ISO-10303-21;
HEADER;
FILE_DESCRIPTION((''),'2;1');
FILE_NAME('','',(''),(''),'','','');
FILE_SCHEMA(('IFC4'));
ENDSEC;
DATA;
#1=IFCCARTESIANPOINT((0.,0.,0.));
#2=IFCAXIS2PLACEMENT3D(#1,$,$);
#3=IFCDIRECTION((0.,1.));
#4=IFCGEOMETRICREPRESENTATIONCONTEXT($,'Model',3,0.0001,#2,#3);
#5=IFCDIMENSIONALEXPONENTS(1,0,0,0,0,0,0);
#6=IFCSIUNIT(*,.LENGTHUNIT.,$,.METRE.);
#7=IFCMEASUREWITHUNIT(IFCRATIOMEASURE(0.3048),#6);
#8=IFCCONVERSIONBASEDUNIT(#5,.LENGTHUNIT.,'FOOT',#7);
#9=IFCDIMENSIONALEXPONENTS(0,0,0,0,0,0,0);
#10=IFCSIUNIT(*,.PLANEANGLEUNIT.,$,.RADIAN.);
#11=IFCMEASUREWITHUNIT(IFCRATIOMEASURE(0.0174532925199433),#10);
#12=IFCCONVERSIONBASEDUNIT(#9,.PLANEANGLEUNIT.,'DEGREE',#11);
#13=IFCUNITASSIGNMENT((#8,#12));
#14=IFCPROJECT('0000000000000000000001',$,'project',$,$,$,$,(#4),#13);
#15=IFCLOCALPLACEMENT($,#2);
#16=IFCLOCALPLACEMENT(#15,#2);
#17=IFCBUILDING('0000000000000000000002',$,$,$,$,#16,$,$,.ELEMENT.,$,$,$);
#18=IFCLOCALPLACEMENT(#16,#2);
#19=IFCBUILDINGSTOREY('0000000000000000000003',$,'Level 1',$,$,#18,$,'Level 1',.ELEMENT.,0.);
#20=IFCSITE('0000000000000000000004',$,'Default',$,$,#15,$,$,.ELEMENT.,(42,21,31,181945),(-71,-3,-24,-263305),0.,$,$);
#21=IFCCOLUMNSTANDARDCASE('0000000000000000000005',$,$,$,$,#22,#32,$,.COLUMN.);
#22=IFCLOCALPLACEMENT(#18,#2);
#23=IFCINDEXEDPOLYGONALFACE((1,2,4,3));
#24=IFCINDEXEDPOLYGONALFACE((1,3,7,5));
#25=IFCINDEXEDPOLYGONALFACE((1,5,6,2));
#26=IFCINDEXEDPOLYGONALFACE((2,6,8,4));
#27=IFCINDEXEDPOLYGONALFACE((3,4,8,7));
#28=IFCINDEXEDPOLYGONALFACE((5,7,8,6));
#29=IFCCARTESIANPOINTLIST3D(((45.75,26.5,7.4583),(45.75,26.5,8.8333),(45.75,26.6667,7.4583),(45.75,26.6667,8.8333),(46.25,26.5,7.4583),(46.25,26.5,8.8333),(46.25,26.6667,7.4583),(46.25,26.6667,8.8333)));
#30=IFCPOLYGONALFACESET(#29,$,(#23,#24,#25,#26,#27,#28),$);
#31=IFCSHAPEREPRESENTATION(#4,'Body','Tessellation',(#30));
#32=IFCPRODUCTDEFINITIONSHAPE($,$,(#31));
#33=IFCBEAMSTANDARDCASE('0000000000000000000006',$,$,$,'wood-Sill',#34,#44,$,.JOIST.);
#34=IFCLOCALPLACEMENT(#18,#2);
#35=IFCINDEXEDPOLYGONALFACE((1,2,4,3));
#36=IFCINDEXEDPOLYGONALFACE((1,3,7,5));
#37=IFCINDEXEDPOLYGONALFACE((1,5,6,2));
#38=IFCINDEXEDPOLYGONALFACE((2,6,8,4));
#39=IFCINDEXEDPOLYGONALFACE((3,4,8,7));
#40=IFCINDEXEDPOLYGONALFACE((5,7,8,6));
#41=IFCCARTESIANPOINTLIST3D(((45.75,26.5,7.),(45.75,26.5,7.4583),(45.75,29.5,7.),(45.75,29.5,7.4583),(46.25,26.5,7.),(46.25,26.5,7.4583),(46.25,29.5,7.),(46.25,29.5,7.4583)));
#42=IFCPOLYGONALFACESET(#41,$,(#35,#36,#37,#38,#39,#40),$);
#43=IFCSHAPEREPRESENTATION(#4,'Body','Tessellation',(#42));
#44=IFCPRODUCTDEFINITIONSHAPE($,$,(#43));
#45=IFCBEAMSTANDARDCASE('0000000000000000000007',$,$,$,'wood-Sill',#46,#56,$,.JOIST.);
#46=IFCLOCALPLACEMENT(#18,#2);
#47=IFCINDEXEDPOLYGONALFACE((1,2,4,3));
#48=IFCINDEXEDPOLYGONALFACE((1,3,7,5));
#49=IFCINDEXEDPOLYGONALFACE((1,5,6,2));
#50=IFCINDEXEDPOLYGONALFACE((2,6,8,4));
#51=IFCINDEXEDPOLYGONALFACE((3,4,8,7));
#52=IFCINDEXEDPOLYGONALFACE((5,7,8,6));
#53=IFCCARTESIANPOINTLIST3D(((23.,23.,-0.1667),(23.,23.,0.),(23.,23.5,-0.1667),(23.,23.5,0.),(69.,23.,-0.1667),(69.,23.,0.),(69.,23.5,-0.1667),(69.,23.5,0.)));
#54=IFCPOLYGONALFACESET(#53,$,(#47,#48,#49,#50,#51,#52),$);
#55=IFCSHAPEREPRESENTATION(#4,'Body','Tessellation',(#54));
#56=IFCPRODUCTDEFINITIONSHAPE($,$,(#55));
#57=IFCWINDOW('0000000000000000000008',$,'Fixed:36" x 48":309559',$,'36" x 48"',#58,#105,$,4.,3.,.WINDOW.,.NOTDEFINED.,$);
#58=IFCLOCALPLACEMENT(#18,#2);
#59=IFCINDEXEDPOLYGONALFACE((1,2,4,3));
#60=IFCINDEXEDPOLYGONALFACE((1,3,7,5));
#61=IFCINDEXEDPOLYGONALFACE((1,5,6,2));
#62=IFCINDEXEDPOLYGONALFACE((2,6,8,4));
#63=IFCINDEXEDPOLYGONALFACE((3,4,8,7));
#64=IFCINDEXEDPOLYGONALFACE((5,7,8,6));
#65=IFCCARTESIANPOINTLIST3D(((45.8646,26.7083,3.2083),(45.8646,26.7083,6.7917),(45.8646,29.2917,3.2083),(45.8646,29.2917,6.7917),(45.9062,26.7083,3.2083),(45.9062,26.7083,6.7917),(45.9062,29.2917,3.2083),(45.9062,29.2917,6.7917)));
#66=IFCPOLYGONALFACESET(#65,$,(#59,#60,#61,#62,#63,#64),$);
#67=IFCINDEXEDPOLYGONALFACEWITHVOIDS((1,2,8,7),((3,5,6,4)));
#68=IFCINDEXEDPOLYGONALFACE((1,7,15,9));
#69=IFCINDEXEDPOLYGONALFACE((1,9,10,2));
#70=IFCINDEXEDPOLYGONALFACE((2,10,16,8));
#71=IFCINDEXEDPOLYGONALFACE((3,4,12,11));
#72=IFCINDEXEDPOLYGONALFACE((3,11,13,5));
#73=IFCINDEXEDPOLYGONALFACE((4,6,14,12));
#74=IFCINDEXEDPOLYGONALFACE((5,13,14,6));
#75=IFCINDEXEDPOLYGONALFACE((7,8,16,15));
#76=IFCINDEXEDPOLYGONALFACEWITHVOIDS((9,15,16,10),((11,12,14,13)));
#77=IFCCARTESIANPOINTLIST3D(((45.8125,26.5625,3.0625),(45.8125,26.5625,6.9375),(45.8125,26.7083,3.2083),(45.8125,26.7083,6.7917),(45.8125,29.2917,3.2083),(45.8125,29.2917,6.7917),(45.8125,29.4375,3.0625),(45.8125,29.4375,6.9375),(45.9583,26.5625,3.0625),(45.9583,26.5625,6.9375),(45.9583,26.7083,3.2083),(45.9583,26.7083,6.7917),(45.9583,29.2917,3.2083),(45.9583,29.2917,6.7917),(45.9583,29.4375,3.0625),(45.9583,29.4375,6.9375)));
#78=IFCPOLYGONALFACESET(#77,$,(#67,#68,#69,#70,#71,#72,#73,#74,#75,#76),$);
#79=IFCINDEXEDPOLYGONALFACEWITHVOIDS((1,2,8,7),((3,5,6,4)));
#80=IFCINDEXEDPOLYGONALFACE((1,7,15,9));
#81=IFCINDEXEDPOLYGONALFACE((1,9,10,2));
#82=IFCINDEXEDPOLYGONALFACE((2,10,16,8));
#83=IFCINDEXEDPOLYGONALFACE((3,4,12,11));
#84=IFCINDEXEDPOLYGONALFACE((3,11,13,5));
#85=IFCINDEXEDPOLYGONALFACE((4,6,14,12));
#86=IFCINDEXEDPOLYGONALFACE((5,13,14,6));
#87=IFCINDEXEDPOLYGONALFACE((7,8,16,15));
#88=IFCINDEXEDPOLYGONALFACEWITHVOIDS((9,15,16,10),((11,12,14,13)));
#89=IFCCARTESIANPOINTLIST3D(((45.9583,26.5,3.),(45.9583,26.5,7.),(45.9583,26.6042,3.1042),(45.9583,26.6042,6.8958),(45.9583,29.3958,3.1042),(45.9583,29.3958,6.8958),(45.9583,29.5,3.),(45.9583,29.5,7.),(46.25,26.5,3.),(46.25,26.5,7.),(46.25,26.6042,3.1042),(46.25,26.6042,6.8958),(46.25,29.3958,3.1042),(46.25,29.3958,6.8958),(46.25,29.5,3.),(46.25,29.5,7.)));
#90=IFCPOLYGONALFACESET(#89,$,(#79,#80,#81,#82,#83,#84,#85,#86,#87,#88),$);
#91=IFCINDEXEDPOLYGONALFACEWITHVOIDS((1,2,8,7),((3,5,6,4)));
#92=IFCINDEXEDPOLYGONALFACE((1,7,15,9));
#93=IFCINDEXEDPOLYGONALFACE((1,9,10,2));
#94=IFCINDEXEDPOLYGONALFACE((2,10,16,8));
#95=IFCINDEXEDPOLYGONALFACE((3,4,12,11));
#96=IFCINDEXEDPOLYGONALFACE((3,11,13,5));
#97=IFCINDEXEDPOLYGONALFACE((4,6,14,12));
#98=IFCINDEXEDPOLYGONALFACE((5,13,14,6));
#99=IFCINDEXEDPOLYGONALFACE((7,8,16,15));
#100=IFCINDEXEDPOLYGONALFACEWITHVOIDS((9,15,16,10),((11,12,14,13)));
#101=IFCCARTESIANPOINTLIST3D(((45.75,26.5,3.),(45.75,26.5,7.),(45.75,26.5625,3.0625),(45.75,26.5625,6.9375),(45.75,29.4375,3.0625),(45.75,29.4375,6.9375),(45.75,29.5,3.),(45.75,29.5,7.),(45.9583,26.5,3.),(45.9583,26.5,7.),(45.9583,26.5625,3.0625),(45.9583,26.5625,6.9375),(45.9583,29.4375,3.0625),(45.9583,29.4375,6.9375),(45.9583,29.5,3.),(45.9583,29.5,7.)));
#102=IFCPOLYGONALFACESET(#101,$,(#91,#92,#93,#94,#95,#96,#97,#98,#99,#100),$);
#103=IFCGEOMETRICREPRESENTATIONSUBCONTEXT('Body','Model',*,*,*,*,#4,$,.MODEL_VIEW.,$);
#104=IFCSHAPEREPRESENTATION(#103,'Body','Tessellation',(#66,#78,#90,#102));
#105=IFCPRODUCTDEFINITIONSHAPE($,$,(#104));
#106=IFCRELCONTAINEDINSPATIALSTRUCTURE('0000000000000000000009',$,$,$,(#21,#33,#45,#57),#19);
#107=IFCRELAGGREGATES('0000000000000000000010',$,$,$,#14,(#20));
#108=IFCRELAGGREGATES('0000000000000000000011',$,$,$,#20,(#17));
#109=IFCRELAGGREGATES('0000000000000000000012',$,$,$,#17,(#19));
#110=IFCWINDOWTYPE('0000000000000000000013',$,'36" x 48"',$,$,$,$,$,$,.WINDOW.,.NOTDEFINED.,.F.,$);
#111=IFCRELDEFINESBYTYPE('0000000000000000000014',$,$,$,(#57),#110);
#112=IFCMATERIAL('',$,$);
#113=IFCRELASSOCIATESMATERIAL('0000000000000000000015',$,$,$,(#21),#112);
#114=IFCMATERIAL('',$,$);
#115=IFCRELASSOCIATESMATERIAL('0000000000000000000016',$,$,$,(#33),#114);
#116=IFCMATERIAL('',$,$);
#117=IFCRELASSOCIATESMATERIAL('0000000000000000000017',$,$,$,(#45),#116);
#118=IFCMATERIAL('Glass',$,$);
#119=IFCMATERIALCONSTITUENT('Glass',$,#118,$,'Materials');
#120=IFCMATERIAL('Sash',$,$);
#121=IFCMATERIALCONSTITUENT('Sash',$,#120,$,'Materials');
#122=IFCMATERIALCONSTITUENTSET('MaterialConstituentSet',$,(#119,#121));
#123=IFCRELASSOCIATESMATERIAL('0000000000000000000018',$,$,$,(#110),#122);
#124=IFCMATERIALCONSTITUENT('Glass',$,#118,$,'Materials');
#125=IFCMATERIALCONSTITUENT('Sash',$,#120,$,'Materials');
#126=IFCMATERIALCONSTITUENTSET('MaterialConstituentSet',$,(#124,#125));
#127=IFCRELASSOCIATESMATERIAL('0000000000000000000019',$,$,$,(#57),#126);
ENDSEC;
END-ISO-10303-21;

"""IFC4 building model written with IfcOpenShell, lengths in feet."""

from ifc_helpers import new_model, entity, si_unit, converted_unit, direction, frame, frame_2d, origin, place, context, subcontext, project, spatial, polyline, rectangle, outline, extrude, source, transform, mapped, material, constituent, constituent_set, type_object, type_shapes, element, save


model = new_model("IFC4")

# Units and contexts
model_context = context("Model", 3, precision=0.0001, world=origin(), true_north=direction((0.0, 1.0)))
body_context = subcontext(model_context, "Body", "Model", "MODEL_VIEW")
ifc_project = project(units=[converted_unit("LENGTHUNIT", "FOOT", entity("IfcRatioMeasure", 0.3048), si_unit("LENGTHUNIT", "METRE"), dimensions=[1, 0, 0, 0, 0, 0, 0]), converted_unit("PLANEANGLEUNIT", "DEGREE", entity("IfcRatioMeasure", 0.0174532925199433), si_unit("PLANEANGLEUNIT", "RADIAN"), dimensions=[0, 0, 0, 0, 0, 0, 0])], contexts=[model_context])

# Site, building, storey
site_placement = place(None, origin())
site = spatial("IfcSite", under=ifc_project, at=site_placement, Name="Default", CompositionType="ELEMENT", RefLatitude=(42, 21, 31, 181945), RefLongitude=(-71, -3, -24, -263305), RefElevation=0.0)
building_placement = place(site_placement, origin())
building = spatial("IfcBuilding", under=site, at=building_placement, CompositionType="ELEMENT")
storey_placement = place(building_placement, origin())
storey = spatial("IfcBuildingStorey", under=building, at=storey_placement, Name="Level 1", LongName="Level 1", CompositionType="ELEMENT", Elevation=0.0)

# Column
placement_1 = place(storey_placement, frame((46.0, 46.25, 0.0), z_axis=(0.0, 0.0, 1.0), x_axis=(0.0, -1.0, 0.0)))
ifc_material_1 = material(Name="")
for number, where, z_axis, x_axis in (
    (1, (19.6667, 0.0, 7.4583), (0.0, 0.0, 1.0), (1.0, 0.0, 0.0)),
):
    element("IfcColumnStandardCase", number, at=place(placement_1, frame(where, z_axis=z_axis, x_axis=x_axis)), inside=storey, material=ifc_material_1, PredefinedType="COLUMN", context=model_context, shape_type="SweptSolid", body=[
        extrude(rectangle(XDim=0.1667, YDim=0.5), origin(), (0.0, 0.0, 1.0), 1.375),
    ])

# Beams
ifc_material_2 = material(Name="")
beam_1_placement = place(placement_1, frame((18.25, 0.0, 7.0), z_axis=(0.0, 0.0, 1.0), x_axis=(-1.0, 0.0, 0.0)))
element("IfcBeamStandardCase", 2, at=beam_1_placement, inside=storey, material=ifc_material_2, ObjectType="wood-Sill", PredefinedType="JOIST", context=model_context, shape_type="SweptSolid", body=[
    extrude(rectangle(XDim=3.0, YDim=0.5), origin(), (0.0, 0.0, 1.0), 0.4583),
])
ifc_material_3 = material(Name="")
beam_2_placement = place(placement_1, frame((23.0, 0.0, -0.1667), z_axis=(0.0, 0.0, 1.0), x_axis=(0.0, -1.0, 0.0)))
element("IfcBeamStandardCase", 3, at=beam_2_placement, inside=storey, material=ifc_material_3, ObjectType="wood-Sill", PredefinedType="JOIST", context=model_context, shape_type="SweptSolid", body=[
    extrude(rectangle(XDim=46.0, YDim=0.5), origin(), (0.0, 0.0, 1.0), 0.1667),
])

# Window
ifc_material_4 = material(Name="Glass")
ifc_constituent_1 = constituent(ifc_material_4, Name="Glass", Category="Materials")
ifc_material_5 = material(Name="Sash")
ifc_constituent_2 = constituent(ifc_material_5, Name="Sash", Category="Materials")
ifc_constituent_set_1 = constituent_set(constituents=[ifc_constituent_1, ifc_constituent_2], Name="MaterialConstituentSet")
ifc_constituent_3 = constituent(ifc_material_4, Name="Glass", Category="Materials")
ifc_constituent_4 = constituent(ifc_material_5, Name="Sash", Category="Materials")
ifc_constituent_set_2 = constituent_set(constituents=[ifc_constituent_3, ifc_constituent_4], Name="MaterialConstituentSet")
window_type = type_object("IfcWindowType", Name="36\" x 48\"", ParameterTakesPrecedence=False, PartitioningType="NOTDEFINED", PredefinedType="WINDOW", material=ifc_constituent_set_2)
shared_shape = source(origin(), body_context, "Body", "SweptSolid", [
    extrude(rectangle(XDim=0.0417, YDim=2.5833, at=frame_2d((0.0, 0.0), x_axis=(1.0, 0.0))), frame((1.5, 0.3646, 0.2083), z_axis=(0.0, 0.0, 1.0), x_axis=(0.0, 1.0, 0.0)), (0.0, 0.0, 1.0), 3.5833),
    extrude(outline(polyline([(-1.4375, -1.9375), (1.4375, -1.9375), (1.4375, 1.9375), (-1.4375, 1.9375), (-1.4375, -1.9375)]), holes=[polyline([(-1.2917, -1.7917), (-1.2917, 1.7917), (1.2917, 1.7917), (1.2917, -1.7917), (-1.2917, -1.7917)])]), frame((1.5, 0.2917, 2.0), z_axis=(0.0, 1.0, 0.0), x_axis=(1.0, 0.0, 0.0)), (0.0, 0.0, 1.0), 0.1458),
    extrude(outline(polyline([(-1.5, -2.0), (1.5, -2.0), (1.5, 2.0), (-1.5, 2.0), (-1.5, -2.0)]), holes=[polyline([(-1.3958, -1.8958), (-1.3958, 1.8958), (1.3958, 1.8958), (1.3958, -1.8958), (-1.3958, -1.8958)])]), frame((1.5, 0.0, 2.0), z_axis=(0.0, 1.0, 0.0), x_axis=(1.0, 0.0, 0.0)), (0.0, 0.0, 1.0), 0.2917),
    extrude(outline(polyline([(-2.0, -1.5), (2.0, -1.5), (2.0, 1.5), (-2.0, 1.5), (-2.0, -1.5)]), holes=[polyline([(-1.9375, -1.4375), (-1.9375, 1.4375), (1.9375, 1.4375), (1.9375, -1.4375), (-1.9375, -1.4375)])]), frame((1.5, 0.2917, 2.0), z_axis=(0.0, 1.0, 0.0), x_axis=(0.0, 0.0, -1.0)), (0.0, 0.0, 1.0), 0.2083),
])
type_shapes(window_type, [shared_shape])
placement_2 = place(placement_1, frame((19.75, 0.25, 3.0)))
window_placement = place(placement_2, frame((0.0, 0.0, 0.0), z_axis=(0.0, 0.0, 1.0), x_axis=(-1.0, 0.0, 0.0)))
element("IfcWindow", 4, at=window_placement, inside=storey, type_object=window_type, material=ifc_constituent_set_1, Name="Fixed:36\" x 48\":309559", ObjectType="36\" x 48\"", OverallHeight=4.0, OverallWidth=3.0, PartitioningType="NOTDEFINED", PredefinedType="WINDOW", context=body_context, shape_type="MappedRepresentation", body=[
    mapped(shared_shape, transform((0.0, 0.0, 0.0), scale=1.0)),
])

save(model, "model.ifc")
